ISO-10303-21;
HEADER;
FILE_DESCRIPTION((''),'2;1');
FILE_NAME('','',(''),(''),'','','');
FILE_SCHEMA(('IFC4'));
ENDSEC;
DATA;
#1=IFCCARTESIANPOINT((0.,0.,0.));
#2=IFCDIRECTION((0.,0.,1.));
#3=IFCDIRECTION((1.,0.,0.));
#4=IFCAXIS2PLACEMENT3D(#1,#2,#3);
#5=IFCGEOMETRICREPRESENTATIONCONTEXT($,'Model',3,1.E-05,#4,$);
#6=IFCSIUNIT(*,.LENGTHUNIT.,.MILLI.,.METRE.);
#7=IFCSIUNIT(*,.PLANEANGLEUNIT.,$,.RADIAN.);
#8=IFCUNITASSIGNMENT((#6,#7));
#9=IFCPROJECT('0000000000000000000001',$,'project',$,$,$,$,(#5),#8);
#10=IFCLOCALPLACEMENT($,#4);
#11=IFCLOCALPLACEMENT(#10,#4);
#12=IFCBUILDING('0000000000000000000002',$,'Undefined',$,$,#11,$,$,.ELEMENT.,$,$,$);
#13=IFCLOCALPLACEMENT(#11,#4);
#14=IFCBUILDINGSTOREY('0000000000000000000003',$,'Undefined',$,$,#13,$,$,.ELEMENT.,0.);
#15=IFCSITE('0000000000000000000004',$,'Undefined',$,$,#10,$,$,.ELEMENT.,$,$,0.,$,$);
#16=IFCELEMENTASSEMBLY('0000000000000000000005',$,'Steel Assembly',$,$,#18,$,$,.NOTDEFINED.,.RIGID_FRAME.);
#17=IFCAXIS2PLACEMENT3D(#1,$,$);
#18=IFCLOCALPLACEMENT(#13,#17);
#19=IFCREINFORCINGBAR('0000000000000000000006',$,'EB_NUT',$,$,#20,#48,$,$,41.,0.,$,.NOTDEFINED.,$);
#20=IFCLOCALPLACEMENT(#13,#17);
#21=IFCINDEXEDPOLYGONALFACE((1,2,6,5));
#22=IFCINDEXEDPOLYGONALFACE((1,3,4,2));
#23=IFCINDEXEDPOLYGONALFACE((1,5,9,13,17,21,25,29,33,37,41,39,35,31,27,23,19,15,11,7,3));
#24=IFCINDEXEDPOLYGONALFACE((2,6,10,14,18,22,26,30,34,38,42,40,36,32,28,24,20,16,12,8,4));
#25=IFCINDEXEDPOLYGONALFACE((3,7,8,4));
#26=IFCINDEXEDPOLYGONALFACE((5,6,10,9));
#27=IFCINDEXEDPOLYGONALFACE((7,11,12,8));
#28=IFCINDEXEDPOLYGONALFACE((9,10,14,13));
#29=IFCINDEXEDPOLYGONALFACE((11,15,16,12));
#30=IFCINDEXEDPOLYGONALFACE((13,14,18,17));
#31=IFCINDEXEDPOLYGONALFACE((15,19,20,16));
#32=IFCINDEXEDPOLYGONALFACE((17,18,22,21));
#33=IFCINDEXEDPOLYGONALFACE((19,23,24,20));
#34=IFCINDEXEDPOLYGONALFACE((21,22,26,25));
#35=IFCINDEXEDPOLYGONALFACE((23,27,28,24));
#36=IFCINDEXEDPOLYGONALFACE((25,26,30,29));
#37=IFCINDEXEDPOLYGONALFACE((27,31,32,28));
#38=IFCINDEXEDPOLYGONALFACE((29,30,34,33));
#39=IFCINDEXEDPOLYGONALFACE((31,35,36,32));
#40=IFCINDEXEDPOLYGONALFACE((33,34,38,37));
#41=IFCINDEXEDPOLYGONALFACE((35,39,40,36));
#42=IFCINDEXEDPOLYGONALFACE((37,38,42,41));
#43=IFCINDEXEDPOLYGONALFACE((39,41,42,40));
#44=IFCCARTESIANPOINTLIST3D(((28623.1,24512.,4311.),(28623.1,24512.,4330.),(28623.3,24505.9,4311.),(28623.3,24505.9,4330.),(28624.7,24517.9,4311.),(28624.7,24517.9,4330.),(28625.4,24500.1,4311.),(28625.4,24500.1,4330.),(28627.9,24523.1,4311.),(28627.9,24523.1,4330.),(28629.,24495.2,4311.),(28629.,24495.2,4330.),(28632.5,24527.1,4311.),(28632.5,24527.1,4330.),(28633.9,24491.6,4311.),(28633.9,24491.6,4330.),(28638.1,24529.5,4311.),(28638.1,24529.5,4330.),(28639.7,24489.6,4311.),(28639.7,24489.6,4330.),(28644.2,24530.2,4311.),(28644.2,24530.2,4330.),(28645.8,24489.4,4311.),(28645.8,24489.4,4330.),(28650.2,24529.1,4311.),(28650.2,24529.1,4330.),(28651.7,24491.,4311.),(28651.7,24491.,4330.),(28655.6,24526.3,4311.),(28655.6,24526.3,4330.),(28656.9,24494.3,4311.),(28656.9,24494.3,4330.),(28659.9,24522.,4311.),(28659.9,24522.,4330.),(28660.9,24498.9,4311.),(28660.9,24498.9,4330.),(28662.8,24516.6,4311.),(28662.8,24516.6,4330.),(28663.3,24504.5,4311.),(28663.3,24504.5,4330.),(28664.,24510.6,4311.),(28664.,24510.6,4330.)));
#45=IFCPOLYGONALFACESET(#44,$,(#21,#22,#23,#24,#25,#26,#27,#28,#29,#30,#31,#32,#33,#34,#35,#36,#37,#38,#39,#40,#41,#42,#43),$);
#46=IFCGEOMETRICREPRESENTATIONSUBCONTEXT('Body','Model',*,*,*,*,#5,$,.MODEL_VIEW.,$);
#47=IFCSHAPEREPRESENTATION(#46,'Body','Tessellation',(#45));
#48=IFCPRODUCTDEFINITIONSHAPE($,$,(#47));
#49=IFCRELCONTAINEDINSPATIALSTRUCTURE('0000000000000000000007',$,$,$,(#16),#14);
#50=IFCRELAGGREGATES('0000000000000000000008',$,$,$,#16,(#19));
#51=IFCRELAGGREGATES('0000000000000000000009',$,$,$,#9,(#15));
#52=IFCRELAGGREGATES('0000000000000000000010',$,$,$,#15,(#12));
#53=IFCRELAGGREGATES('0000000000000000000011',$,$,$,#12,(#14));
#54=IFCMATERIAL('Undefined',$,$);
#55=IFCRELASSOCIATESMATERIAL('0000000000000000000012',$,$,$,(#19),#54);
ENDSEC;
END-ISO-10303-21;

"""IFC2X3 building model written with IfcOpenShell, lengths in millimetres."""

from ifc_helpers import new_model, entity, si_unit, frame, origin_with_axes, place, context, subcontext, project, spatial, source, transform, mapped, material, element, aggregate, save


model = new_model("IFC2X3")

# Units and contexts
model_context = context("Model", 3, precision=1e-05, world=origin_with_axes())
body_context = subcontext(model_context, "Body", "Model", "MODEL_VIEW")
ifc_project = project(units=[si_unit("LENGTHUNIT", "METRE", prefix="MILLI"), si_unit("PLANEANGLEUNIT", "RADIAN")], contexts=[model_context])

# Site, building, storey
site_placement = place(None, origin_with_axes())
site = spatial("IfcSite", under=ifc_project, at=site_placement, Name="Undefined", CompositionType="ELEMENT", RefElevation=0.0)
building_placement = place(site_placement, origin_with_axes())
building = spatial("IfcBuilding", under=site, at=building_placement, Name="Undefined", CompositionType="ELEMENT")
storey_placement = place(building_placement, origin_with_axes())
storey = spatial("IfcBuildingStorey", under=building, at=storey_placement, Name="Undefined", CompositionType="ELEMENT", Elevation=0.0)

# Element assembly
assembly_1_placement = place(storey_placement, origin_with_axes())
assembly_1 = element("IfcElementAssembly", 1, at=assembly_1_placement, inside=storey, Name="Steel Assembly", AssemblyPlace="NOTDEFINED", PredefinedType="RIGID_FRAME")

# Shared definitions
ifc_material_1 = material(Name="Undefined")

# Reinforcing bar
shared_shape_1 = source(origin_with_axes(), body_context, "Body", "AdvancedSweptSolid", [
    entity("IfcSweptDiskSolid", entity("IfcTrimmedCurve", entity("IfcLine", entity("IfcCartesianPoint", [0.0, 0.0, 0.0]), entity("IfcVector", entity("IfcDirection", [1.0, 0.0, 0.0]), 1.0)), [entity("IfcParameterValue", 0.0)], [entity("IfcParameterValue", 19.0)], True, "PARAMETER"), 20.5, None, 0.0, 19.0),
])
reinforcing_bar_1_placement = place(assembly_1_placement, frame((28643.5, 24509.8, 4330.0), z_axis=(-0.534023, 0.84547, 0.0), x_axis=(0.0, 0.0, -1.0)))
reinforcing_bar_1 = element("IfcReinforcingBar", 2, at=reinforcing_bar_1_placement, material=ifc_material_1, Name="EB_NUT", BarRole="NOTDEFINED", CrossSectionArea=0.0, NominalDiameter=41.0, context=body_context, shape_type="MappedRepresentation", body=[
    mapped(shared_shape_1, transform((0.0, 0.0, 0.0))),
])
aggregate(assembly_1, [reinforcing_bar_1])

save(model, "model.ifc")
